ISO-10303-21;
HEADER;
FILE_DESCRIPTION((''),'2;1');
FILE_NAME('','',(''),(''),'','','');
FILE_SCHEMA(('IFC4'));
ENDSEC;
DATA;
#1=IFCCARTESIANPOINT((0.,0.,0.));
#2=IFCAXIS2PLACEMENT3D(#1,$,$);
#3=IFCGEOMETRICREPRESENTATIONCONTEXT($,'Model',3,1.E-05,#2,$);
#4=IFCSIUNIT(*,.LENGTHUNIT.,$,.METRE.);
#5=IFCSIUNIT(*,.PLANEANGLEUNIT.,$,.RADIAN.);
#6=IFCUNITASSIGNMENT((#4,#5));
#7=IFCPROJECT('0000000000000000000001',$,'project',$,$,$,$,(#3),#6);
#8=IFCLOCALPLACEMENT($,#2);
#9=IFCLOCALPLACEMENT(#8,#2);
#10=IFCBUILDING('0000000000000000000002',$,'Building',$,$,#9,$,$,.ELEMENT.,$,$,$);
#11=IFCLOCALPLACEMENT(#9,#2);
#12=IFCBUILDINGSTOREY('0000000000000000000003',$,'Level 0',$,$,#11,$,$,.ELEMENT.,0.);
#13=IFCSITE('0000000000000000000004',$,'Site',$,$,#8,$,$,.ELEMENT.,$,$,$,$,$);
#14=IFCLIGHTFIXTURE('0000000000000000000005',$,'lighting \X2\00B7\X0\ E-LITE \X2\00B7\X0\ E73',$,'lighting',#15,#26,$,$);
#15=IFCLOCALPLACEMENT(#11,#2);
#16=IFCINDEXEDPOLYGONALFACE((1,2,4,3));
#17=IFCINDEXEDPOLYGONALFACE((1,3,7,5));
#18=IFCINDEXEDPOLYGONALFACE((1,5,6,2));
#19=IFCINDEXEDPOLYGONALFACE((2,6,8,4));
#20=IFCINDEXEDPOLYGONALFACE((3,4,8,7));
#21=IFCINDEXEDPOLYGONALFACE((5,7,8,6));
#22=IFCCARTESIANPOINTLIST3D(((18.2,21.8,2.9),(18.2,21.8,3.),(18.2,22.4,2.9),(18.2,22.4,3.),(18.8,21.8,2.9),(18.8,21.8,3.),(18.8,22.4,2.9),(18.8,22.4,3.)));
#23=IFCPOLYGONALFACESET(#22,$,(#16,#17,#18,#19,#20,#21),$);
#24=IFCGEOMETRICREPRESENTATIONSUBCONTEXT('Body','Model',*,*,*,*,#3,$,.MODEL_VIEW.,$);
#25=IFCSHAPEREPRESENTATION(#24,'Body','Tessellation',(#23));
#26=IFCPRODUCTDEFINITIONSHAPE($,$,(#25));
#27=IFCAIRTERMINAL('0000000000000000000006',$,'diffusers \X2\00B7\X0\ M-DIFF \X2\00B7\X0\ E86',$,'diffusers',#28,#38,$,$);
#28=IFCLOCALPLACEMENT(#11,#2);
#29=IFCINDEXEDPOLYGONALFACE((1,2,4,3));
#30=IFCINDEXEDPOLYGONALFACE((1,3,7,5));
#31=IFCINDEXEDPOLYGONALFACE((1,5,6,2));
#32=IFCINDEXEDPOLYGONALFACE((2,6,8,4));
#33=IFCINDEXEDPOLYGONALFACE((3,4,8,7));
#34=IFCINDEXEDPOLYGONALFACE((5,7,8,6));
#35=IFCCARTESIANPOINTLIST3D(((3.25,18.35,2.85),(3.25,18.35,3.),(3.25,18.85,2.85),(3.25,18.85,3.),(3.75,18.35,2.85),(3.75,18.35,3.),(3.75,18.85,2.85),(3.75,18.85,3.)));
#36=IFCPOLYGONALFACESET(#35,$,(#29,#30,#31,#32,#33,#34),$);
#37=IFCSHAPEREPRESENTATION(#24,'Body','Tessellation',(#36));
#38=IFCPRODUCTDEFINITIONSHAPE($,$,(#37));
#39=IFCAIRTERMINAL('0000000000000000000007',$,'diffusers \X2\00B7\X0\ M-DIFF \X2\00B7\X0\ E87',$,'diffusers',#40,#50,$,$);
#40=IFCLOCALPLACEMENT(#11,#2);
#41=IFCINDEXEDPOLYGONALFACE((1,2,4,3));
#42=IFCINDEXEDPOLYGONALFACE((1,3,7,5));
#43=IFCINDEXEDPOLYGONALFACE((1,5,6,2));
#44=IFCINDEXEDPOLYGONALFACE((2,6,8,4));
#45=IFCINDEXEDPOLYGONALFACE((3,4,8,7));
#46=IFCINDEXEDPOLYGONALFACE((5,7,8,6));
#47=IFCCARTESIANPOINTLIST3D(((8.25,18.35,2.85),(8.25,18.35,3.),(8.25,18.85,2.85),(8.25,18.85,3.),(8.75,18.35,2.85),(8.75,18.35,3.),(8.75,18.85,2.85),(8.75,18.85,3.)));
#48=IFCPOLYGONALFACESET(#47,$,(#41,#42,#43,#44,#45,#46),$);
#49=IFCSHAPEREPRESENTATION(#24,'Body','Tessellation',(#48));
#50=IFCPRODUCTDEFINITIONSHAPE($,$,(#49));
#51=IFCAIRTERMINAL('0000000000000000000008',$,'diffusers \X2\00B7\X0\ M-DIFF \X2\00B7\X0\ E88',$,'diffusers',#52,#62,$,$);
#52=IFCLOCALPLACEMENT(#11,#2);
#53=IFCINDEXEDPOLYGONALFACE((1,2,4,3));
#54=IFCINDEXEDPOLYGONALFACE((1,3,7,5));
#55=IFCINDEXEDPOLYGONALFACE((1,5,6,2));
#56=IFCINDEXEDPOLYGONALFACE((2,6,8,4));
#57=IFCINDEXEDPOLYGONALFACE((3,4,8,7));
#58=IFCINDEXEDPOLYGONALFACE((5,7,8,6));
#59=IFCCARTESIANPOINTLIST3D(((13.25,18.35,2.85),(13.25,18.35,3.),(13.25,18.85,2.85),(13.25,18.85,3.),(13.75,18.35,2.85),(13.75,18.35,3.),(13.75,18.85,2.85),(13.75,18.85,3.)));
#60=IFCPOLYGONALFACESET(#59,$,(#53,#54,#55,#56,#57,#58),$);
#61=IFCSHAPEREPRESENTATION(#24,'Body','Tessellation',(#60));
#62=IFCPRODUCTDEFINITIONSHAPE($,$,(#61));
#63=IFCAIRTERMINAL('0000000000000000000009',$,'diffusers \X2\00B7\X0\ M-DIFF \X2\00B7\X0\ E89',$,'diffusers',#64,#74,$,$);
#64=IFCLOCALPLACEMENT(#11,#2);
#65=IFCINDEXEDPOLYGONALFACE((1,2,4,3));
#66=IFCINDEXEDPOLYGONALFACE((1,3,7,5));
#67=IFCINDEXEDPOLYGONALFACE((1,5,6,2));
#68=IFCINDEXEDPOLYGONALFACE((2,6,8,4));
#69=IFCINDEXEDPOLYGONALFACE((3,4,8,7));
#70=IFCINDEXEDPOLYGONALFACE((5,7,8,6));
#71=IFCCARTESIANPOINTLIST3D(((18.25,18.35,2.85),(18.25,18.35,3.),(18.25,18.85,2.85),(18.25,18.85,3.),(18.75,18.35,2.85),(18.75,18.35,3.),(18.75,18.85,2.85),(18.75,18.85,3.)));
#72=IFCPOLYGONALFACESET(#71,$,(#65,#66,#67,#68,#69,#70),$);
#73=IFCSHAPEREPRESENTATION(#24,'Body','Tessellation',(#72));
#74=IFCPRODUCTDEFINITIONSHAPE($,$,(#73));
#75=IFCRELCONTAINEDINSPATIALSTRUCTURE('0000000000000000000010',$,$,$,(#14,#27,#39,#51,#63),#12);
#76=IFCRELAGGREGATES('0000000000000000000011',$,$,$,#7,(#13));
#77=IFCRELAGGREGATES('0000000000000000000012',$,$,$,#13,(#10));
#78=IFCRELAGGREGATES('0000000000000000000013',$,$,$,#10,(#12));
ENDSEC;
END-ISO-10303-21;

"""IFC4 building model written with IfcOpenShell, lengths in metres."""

from ifc_helpers import new_model, si_unit, frame, origin, place, context, subcontext, project, spatial, polyline, outline, extrude, element, save


model = new_model("IFC4")

# Units and contexts
model_context = context("Model", 3, precision=1e-05, world=origin())
body_context = subcontext(model_context, "Body", "Model", "MODEL_VIEW")
ifc_project = project(units=[si_unit("LENGTHUNIT", "METRE"), si_unit("PLANEANGLEUNIT", "RADIAN")], contexts=[model_context])

# Site, building, storey
site_placement = place(None, origin())
site = spatial("IfcSite", under=ifc_project, at=site_placement, Name="Site", CompositionType="ELEMENT")
building_placement = place(site_placement, origin())
building = spatial("IfcBuilding", under=site, at=building_placement, Name="Building", CompositionType="ELEMENT")
storey_placement = place(building_placement, origin())
storey = spatial("IfcBuildingStorey", under=building, at=storey_placement, Name="Level 0", CompositionType="ELEMENT", Elevation=0.0)

# Light fixture
light_fixture_1_placement = place(storey_placement, frame((0.0, 0.0, 2.9)))
element("IfcLightFixture", 1, at=light_fixture_1_placement, inside=storey, Name="lighting · E-LITE · E73", ObjectType="lighting", context=body_context, shape_type="SweptSolid", body=[
    extrude(outline(polyline([(18.2, 21.8), (18.8, 21.8), (18.8, 22.4), (18.2, 22.4), (18.2, 21.8)])), origin(), (0.0, 0.0, 1.0), 0.1),
])

# Air terminals
air_terminal_1_placement = place(storey_placement, frame((0.0, 0.0, 2.85)))
element("IfcAirTerminal", 2, at=air_terminal_1_placement, inside=storey, Name="diffusers · M-DIFF · E86", ObjectType="diffusers", context=body_context, shape_type="SweptSolid", body=[
    extrude(outline(polyline([(3.25, 18.35), (3.75, 18.35), (3.75, 18.85), (3.25, 18.85), (3.25, 18.35)])), origin(), (0.0, 0.0, 1.0), 0.15),
])
air_terminal_2_placement = place(storey_placement, frame((0.0, 0.0, 2.85)))
element("IfcAirTerminal", 3, at=air_terminal_2_placement, inside=storey, Name="diffusers · M-DIFF · E87", ObjectType="diffusers", context=body_context, shape_type="SweptSolid", body=[
    extrude(outline(polyline([(8.25, 18.35), (8.75, 18.35), (8.75, 18.85), (8.25, 18.85), (8.25, 18.35)])), origin(), (0.0, 0.0, 1.0), 0.15),
])
air_terminal_3_placement = place(storey_placement, frame((0.0, 0.0, 2.85)))
element("IfcAirTerminal", 4, at=air_terminal_3_placement, inside=storey, Name="diffusers · M-DIFF · E88", ObjectType="diffusers", context=body_context, shape_type="SweptSolid", body=[
    extrude(outline(polyline([(13.25, 18.35), (13.75, 18.35), (13.75, 18.85), (13.25, 18.85), (13.25, 18.35)])), origin(), (0.0, 0.0, 1.0), 0.15),
])
air_terminal_4_placement = place(storey_placement, frame((0.0, 0.0, 2.85)))
element("IfcAirTerminal", 5, at=air_terminal_4_placement, inside=storey, Name="diffusers · M-DIFF · E89", ObjectType="diffusers", context=body_context, shape_type="SweptSolid", body=[
    extrude(outline(polyline([(18.25, 18.35), (18.75, 18.35), (18.75, 18.85), (18.25, 18.85), (18.25, 18.35)])), origin(), (0.0, 0.0, 1.0), 0.15),
])

save(model, "model.ifc")
